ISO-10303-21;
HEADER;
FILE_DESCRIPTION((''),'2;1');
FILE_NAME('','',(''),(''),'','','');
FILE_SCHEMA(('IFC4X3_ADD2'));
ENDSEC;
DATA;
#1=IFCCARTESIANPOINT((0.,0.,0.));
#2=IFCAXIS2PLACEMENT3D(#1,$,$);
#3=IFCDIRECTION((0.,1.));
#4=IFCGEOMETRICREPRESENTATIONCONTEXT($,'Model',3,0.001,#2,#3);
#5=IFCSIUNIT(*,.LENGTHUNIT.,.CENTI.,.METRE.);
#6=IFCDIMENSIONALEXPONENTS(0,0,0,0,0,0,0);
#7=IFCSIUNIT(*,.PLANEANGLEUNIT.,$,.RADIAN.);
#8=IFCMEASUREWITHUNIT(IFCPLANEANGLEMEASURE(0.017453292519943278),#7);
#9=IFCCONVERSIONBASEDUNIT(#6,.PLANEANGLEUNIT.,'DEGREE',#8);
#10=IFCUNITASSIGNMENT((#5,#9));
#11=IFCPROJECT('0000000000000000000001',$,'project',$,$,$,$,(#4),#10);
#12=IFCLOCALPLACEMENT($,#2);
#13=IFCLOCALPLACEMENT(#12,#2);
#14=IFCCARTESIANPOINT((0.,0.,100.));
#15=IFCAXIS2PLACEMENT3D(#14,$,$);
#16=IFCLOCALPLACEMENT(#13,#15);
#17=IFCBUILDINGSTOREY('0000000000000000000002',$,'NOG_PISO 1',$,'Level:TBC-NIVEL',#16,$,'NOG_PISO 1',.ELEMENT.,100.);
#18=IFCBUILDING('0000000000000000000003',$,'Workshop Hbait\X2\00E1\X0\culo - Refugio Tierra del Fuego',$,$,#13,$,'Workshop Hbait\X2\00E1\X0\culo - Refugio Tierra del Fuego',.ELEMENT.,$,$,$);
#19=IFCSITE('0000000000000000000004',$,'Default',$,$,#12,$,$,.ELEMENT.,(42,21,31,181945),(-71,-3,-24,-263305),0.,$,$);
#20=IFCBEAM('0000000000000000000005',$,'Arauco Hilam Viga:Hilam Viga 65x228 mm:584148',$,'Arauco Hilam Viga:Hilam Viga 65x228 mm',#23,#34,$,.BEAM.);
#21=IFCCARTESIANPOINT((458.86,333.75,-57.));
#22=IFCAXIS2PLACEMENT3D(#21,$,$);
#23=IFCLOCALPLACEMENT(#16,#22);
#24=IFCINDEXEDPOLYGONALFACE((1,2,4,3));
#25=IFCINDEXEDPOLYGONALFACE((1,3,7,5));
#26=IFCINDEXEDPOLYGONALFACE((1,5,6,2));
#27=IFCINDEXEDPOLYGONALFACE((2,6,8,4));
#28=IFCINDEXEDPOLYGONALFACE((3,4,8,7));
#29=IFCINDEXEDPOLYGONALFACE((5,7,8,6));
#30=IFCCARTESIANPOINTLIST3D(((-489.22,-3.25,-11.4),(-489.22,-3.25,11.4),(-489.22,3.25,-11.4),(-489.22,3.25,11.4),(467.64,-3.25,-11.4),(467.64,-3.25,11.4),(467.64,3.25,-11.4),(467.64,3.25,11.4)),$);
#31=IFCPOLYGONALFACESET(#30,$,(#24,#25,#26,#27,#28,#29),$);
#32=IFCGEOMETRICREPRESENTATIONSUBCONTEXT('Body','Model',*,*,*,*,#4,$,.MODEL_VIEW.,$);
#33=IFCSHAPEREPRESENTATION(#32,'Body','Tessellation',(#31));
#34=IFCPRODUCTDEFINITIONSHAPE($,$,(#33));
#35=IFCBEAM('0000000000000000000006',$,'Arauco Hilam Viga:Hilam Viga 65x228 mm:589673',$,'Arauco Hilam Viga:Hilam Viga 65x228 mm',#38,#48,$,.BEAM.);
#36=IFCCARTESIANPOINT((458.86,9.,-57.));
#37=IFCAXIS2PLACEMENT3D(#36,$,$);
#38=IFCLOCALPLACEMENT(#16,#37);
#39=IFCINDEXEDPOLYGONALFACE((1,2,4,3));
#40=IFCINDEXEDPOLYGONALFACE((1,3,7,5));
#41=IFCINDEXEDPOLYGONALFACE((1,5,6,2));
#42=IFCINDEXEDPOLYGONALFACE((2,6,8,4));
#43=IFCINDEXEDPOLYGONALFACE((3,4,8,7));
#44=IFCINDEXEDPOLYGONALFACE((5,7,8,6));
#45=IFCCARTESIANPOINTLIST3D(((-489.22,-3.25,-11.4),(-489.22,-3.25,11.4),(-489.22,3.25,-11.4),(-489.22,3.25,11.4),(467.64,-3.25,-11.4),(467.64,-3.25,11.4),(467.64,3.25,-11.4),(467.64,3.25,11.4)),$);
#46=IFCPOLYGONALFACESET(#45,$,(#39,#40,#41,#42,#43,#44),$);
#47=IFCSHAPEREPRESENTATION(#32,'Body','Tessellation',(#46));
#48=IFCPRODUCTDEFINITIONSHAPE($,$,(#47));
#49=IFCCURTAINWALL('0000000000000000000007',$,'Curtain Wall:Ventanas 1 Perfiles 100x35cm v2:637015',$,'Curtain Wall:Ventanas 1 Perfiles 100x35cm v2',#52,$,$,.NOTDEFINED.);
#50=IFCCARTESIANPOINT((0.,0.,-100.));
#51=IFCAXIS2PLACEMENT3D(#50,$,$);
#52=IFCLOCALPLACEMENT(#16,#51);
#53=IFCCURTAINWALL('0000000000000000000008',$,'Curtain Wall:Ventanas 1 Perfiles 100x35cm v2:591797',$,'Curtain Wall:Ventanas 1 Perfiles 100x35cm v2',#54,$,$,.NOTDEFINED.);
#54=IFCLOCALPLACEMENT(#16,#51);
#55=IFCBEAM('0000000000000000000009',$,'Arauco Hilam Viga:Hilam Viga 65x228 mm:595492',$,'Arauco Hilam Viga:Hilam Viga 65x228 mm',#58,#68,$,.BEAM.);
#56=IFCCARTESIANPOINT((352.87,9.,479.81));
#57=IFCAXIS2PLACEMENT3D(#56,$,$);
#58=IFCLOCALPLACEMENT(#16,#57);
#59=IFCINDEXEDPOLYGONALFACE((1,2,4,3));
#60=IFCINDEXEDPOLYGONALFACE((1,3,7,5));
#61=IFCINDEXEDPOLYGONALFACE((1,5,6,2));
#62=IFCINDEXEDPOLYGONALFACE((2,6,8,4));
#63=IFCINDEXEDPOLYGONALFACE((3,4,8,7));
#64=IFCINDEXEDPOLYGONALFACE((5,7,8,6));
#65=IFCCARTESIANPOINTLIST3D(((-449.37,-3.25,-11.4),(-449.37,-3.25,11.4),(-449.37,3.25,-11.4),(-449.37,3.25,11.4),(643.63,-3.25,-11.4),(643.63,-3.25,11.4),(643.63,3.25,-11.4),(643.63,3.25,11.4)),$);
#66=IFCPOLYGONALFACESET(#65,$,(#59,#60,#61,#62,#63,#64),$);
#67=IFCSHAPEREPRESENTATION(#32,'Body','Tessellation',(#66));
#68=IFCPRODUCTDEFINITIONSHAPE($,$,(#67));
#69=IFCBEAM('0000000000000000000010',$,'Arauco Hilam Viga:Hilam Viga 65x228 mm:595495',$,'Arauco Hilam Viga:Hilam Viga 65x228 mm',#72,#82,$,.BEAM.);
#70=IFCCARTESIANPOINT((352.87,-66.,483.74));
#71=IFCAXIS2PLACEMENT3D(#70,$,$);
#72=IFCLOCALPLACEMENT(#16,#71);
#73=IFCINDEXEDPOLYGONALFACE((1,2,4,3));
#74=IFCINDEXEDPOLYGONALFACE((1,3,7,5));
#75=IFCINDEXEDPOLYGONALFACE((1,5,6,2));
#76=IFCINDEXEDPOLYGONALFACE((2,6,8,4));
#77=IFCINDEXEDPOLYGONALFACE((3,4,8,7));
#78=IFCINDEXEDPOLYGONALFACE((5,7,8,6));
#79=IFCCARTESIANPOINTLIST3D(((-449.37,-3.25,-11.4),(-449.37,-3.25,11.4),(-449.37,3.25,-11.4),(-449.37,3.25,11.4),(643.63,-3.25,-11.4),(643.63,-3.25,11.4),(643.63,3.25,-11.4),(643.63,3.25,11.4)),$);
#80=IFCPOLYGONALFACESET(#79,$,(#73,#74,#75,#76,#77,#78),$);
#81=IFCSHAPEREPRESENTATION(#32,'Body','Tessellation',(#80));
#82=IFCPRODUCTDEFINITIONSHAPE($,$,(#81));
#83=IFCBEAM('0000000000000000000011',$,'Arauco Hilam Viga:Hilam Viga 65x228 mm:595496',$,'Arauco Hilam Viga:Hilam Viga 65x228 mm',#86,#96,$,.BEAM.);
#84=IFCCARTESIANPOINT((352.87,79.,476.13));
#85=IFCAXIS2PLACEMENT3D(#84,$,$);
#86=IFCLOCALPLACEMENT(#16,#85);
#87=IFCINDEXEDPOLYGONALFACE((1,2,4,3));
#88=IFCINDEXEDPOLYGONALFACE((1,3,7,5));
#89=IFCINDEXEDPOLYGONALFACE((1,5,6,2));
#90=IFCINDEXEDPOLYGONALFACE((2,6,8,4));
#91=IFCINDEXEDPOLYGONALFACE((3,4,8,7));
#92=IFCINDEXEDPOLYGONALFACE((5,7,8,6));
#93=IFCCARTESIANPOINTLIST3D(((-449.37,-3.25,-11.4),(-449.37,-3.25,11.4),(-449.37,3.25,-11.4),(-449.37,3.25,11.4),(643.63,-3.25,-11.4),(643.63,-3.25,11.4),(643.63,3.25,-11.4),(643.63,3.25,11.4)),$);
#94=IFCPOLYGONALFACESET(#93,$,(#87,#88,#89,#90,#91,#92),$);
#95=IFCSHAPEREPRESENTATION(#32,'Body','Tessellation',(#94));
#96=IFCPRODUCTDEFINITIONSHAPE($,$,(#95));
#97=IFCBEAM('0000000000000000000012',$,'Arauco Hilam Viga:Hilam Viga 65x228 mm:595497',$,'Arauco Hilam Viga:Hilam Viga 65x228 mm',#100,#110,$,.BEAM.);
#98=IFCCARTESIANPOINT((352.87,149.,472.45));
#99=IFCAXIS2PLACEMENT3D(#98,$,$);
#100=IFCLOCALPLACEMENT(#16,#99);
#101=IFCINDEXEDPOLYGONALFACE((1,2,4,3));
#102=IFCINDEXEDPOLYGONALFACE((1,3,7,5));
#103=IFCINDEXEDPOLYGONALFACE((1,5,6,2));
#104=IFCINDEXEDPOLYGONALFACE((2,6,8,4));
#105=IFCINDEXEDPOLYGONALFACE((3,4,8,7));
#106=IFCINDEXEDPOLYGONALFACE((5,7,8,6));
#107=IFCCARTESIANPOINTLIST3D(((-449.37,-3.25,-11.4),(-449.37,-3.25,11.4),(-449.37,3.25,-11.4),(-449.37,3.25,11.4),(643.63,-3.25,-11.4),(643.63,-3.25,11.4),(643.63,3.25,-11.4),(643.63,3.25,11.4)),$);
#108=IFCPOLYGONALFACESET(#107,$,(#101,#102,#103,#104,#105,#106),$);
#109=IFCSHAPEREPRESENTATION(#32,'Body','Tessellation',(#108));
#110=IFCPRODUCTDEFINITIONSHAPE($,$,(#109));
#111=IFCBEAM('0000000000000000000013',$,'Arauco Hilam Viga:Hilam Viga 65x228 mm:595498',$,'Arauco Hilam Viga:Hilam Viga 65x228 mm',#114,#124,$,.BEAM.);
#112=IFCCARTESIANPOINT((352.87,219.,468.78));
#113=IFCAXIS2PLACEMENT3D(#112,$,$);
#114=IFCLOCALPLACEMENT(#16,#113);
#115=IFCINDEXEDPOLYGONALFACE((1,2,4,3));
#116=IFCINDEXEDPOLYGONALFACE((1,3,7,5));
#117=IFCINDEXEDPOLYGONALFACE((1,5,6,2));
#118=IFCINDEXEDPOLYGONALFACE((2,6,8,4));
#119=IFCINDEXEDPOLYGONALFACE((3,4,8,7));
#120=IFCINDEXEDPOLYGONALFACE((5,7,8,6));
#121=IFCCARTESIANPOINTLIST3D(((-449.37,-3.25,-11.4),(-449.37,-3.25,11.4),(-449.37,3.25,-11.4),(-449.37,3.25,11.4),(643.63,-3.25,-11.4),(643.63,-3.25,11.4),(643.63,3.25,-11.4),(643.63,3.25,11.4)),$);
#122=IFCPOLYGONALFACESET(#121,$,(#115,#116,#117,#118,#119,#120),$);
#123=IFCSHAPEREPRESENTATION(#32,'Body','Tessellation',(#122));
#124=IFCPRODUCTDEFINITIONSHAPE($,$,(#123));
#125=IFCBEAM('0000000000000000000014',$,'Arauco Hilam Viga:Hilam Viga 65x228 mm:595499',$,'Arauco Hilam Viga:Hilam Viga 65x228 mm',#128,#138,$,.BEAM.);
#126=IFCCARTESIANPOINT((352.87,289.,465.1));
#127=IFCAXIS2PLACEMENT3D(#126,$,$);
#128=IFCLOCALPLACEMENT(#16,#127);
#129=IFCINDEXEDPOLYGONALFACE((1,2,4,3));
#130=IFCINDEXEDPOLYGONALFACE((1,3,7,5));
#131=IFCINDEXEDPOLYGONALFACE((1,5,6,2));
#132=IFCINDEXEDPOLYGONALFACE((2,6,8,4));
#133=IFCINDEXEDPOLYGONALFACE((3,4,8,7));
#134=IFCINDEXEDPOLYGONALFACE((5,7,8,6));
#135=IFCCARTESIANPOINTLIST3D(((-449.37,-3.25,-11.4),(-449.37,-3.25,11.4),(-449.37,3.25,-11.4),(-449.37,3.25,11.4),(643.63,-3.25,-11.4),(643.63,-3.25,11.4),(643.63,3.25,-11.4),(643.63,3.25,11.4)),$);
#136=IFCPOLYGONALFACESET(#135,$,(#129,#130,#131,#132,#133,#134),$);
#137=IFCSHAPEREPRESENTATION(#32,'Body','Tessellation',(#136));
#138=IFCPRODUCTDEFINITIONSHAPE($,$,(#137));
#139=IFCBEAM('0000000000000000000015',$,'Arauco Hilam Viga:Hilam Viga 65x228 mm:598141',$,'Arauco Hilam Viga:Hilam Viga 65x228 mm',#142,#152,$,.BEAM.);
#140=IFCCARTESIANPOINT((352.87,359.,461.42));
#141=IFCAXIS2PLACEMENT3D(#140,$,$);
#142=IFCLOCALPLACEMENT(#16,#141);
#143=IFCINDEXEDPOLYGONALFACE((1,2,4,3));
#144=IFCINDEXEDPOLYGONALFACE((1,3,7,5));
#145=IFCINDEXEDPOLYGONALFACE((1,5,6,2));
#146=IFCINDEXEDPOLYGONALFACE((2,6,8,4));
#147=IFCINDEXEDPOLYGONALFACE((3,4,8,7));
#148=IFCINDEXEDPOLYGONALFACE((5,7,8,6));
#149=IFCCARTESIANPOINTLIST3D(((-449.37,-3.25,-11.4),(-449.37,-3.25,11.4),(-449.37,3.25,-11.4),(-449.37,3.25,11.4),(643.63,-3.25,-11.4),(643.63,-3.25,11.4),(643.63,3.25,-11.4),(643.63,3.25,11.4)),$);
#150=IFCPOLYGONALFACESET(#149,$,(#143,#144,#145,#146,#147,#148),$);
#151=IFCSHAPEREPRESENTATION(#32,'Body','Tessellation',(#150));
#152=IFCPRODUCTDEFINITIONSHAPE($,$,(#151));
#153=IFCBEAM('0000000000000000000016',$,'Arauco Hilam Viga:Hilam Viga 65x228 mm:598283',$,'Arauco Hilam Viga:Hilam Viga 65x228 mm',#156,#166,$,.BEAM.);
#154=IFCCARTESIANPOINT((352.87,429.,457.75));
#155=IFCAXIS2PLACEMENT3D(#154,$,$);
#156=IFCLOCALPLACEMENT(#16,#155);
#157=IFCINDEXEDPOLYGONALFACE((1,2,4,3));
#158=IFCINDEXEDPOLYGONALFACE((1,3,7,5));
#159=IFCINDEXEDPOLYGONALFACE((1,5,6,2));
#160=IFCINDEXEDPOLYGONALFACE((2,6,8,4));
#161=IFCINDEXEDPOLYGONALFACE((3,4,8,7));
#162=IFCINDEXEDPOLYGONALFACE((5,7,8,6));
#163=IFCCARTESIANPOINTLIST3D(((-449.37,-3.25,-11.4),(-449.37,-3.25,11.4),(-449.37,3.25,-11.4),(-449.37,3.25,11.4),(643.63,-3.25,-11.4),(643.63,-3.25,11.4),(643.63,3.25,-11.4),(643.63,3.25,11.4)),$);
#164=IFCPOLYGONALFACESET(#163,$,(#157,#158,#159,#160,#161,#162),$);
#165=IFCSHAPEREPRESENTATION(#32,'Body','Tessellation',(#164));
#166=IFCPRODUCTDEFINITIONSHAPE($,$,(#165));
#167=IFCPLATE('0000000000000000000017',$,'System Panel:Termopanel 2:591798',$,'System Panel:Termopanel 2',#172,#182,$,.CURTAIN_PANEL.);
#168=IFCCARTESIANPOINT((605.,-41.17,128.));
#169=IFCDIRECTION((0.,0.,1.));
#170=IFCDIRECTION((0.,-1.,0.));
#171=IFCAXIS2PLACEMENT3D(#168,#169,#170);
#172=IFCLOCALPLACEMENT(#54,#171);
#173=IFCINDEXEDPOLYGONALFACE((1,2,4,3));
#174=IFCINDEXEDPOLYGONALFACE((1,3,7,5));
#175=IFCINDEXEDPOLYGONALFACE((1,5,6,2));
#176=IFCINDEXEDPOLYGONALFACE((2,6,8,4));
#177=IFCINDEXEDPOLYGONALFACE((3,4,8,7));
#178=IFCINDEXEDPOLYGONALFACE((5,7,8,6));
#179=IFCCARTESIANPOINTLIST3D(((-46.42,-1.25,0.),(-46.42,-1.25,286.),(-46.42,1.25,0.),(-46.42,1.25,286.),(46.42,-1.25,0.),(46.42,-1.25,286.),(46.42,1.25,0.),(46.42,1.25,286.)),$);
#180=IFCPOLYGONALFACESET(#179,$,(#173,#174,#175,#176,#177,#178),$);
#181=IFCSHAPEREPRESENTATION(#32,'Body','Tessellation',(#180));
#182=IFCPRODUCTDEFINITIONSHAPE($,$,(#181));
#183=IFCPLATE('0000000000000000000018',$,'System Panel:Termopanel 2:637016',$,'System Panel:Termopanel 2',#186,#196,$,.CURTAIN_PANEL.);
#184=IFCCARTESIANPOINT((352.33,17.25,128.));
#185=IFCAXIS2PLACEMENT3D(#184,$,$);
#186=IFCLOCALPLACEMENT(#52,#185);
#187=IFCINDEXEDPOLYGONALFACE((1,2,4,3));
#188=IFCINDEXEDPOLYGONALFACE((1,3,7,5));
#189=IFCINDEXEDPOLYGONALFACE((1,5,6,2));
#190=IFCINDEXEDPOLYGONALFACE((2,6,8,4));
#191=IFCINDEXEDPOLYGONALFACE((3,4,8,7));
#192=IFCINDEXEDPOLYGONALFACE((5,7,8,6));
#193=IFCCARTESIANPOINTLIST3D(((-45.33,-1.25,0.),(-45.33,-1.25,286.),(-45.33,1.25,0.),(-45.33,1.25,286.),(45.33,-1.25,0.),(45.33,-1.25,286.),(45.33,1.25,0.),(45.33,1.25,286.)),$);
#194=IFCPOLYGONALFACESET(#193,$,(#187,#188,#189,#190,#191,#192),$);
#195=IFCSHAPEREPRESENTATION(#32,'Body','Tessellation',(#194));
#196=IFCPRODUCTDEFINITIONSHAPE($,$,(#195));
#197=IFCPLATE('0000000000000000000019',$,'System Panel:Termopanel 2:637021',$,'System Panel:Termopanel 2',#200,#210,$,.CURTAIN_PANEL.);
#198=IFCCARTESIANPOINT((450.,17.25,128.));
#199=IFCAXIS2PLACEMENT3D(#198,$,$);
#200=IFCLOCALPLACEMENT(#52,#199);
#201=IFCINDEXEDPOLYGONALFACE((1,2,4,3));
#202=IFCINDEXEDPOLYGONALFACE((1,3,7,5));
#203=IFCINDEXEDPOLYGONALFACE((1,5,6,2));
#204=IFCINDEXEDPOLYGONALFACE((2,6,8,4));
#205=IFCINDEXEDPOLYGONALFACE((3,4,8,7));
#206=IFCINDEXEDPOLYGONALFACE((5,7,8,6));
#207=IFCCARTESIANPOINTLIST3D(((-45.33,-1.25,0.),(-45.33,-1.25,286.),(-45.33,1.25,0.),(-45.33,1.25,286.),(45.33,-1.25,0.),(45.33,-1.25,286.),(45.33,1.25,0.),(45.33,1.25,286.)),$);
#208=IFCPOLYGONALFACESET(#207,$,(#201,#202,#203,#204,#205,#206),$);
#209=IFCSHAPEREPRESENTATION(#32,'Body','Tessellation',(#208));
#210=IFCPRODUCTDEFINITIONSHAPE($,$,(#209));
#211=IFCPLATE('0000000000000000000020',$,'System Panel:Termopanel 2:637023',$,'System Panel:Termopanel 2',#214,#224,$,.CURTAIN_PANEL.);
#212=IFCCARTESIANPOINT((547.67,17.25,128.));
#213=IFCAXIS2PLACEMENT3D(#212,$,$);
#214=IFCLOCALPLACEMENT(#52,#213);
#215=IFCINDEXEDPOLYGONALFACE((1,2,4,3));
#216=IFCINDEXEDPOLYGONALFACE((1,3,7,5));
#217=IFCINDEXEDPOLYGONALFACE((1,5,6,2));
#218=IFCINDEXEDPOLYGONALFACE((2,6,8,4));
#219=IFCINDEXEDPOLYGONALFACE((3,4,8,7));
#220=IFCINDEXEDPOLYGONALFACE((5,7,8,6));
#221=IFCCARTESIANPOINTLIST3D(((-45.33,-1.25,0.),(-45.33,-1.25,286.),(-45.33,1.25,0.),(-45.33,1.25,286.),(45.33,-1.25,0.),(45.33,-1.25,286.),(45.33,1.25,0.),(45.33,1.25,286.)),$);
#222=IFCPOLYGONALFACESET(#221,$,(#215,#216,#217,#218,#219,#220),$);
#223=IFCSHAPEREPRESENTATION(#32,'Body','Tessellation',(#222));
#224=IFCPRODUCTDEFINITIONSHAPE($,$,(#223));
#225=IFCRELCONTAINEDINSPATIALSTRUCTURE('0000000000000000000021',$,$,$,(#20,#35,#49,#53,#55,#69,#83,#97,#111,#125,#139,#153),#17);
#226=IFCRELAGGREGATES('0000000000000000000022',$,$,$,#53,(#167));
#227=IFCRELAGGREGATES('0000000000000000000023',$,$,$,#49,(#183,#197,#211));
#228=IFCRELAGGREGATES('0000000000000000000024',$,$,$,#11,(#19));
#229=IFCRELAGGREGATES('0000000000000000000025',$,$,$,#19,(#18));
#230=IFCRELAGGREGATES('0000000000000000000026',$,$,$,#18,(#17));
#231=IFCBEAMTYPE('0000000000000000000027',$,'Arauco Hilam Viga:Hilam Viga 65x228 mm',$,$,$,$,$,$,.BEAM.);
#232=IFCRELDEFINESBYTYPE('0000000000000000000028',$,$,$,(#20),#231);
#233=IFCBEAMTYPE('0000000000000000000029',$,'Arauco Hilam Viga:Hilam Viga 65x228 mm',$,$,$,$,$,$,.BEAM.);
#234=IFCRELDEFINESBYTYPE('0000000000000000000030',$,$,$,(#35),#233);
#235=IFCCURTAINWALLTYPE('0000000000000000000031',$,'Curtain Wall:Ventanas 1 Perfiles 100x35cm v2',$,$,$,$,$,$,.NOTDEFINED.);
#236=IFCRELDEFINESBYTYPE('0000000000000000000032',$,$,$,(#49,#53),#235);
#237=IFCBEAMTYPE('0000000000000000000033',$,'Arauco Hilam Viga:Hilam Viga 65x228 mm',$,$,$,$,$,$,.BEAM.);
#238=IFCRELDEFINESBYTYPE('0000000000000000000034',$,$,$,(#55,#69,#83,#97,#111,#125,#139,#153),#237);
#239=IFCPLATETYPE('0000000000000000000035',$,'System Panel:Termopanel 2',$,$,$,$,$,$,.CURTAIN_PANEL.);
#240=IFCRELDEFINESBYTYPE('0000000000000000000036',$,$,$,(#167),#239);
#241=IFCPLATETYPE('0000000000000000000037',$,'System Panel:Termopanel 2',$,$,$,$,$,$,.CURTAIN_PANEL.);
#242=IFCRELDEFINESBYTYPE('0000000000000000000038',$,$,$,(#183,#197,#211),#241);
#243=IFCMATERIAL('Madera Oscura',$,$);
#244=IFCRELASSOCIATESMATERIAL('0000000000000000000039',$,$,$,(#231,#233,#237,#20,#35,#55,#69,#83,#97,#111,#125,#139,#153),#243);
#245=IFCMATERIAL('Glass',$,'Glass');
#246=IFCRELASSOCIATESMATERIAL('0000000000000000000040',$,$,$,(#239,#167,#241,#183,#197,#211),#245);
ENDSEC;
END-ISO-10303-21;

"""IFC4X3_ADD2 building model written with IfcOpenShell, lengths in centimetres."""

from ifc_helpers import new_model, entity, si_unit, converted_unit, direction, frame, origin, origin_2d_with_axis, place, context, subcontext, project, spatial, rectangle, extrude, source, transform, mapped, material, material_profile, profile_set, profile_usage, type_object, type_shapes, element, aggregate, save


model = new_model("IFC4X3_ADD2")

# Units and contexts
model_context = context("Model", 3, precision=0.001, world=origin(), true_north=direction((0.0, 1.0)))
body_context = subcontext(model_context, "Body", "Model", "MODEL_VIEW")
ifc_project = project(units=[si_unit("LENGTHUNIT", "METRE", prefix="CENTI"), converted_unit("PLANEANGLEUNIT", "DEGREE", entity("IfcPlaneAngleMeasure", 0.017453292519943278), si_unit("PLANEANGLEUNIT", "RADIAN"), dimensions=[0, 0, 0, 0, 0, 0, 0])], contexts=[model_context])

# Site, building, storey
site_placement = place(None, origin())
site = spatial("IfcSite", under=ifc_project, at=site_placement, Name="Default", CompositionType="ELEMENT", RefLatitude=(42, 21, 31, 181945), RefLongitude=(-71, -3, -24, -263305), RefElevation=0.0)
building_placement = place(site_placement, origin())
building = spatial("IfcBuilding", under=site, at=building_placement, Name="Workshop Hbaitáculo - Refugio Tierra del Fuego", LongName="Workshop Hbaitáculo - Refugio Tierra del Fuego", CompositionType="ELEMENT")
storey_placement = place(building_placement, frame((0.0, 0.0, 100.0)))
storey = spatial("IfcBuildingStorey", under=building, at=storey_placement, Name="NOG_PISO 1", ObjectType="Level:TBC-NIVEL", LongName="NOG_PISO 1", CompositionType="ELEMENT", Elevation=100.0)

# Beams
ifc_material_1 = material(Name="Madera Oscura")
ifc_material_profile_1 = material_profile(ifc_material_1, rectangle(XDim=930.0, YDim=6.5, at=origin_2d_with_axis()), Name="Hilam Viga 65x228 mm")
ifc_profile_set_1 = profile_set([ifc_material_profile_1], Name="Hilam Viga 65x228 mm")
ifc_profile_usage_1 = profile_usage(ifc_profile_set_1, cardinal=8)
beam_type_1 = type_object("IfcBeamType", Name="Arauco Hilam Viga:Hilam Viga 65x228 mm", PredefinedType="BEAM", material=ifc_profile_set_1)
shared_shape_1 = source(origin(), body_context, "Body", "SweptSolid", [
    extrude(rectangle(XDim=956.86, YDim=6.5, at=origin_2d_with_axis()), frame((-10.79, 0.0, -11.4), z_axis=(0.0, 0.0, 1.0), x_axis=(-1.0, 0.0, 0.0)), (0.0, 0.0, 1.0), 22.8),
])
type_shapes(beam_type_1, [shared_shape_1])
beam_1_placement = place(storey_placement, frame((458.86, 333.75, -57.0)))
element("IfcBeam", 1, at=beam_1_placement, inside=storey, type_object=beam_type_1, material=ifc_profile_usage_1, Name="Arauco Hilam Viga:Hilam Viga 65x228 mm:584148", ObjectType="Arauco Hilam Viga:Hilam Viga 65x228 mm", PredefinedType="BEAM", context=body_context, shape_type="MappedRepresentation", body=[
    mapped(shared_shape_1, transform((0.0, 0.0, 0.0), scale=1.0)),
])
beam_type_2 = type_object("IfcBeamType", Name="Arauco Hilam Viga:Hilam Viga 65x228 mm", PredefinedType="BEAM", material=ifc_profile_set_1)
shared_shape_2 = source(origin(), body_context, "Body", "SweptSolid", [
    extrude(rectangle(XDim=6.5, YDim=956.86, at=origin_2d_with_axis()), frame((-10.79, 0.0, -11.4), z_axis=(0.0, 0.0, 1.0), x_axis=(0.0, 1.0, 0.0)), (0.0, 0.0, 1.0), 22.8),
])
type_shapes(beam_type_2, [shared_shape_2])
beam_2_placement = place(storey_placement, frame((458.86, 9.0, -57.0)))
element("IfcBeam", 2, at=beam_2_placement, inside=storey, type_object=beam_type_2, material=ifc_profile_usage_1, Name="Arauco Hilam Viga:Hilam Viga 65x228 mm:589673", ObjectType="Arauco Hilam Viga:Hilam Viga 65x228 mm", PredefinedType="BEAM", context=body_context, shape_type="MappedRepresentation", body=[
    mapped(shared_shape_2, transform((0.0, 0.0, 0.0), scale=1.0)),
])

# Curtain walls
curtain_wall_type = type_object("IfcCurtainWallType", Name="Curtain Wall:Ventanas 1 Perfiles 100x35cm v2", PredefinedType="NOTDEFINED")
curtain_wall_1_placement = place(storey_placement, frame((0.0, 0.0, -100.0)))
curtain_wall_1 = element("IfcCurtainWall", 3, at=curtain_wall_1_placement, inside=storey, type_object=curtain_wall_type, Name="Curtain Wall:Ventanas 1 Perfiles 100x35cm v2:637015", ObjectType="Curtain Wall:Ventanas 1 Perfiles 100x35cm v2", PredefinedType="NOTDEFINED")
curtain_wall_2_placement = place(storey_placement, frame((0.0, 0.0, -100.0)))
curtain_wall_2 = element("IfcCurtainWall", 4, at=curtain_wall_2_placement, inside=storey, type_object=curtain_wall_type, Name="Curtain Wall:Ventanas 1 Perfiles 100x35cm v2:591797", ObjectType="Curtain Wall:Ventanas 1 Perfiles 100x35cm v2", PredefinedType="NOTDEFINED")

# Beams
beam_type_3 = type_object("IfcBeamType", Name="Arauco Hilam Viga:Hilam Viga 65x228 mm", PredefinedType="BEAM", material=ifc_profile_set_1)
shared_shape_3 = source(origin(), body_context, "Body", "SweptSolid", [
    extrude(rectangle(XDim=1093.0, YDim=6.5, at=origin_2d_with_axis()), frame((97.13, 0.0, -11.4), z_axis=(0.0, 0.0, 1.0), x_axis=(-1.0, 0.0, 0.0)), (0.0, 0.0, 1.0), 22.8),
])
type_shapes(beam_type_3, [shared_shape_3])
for number, where, name in (
    (5, (352.87, 9.0, 479.81), "Arauco Hilam Viga:Hilam Viga 65x228 mm:595492"),
    (6, (352.87, -66.0, 483.74), "Arauco Hilam Viga:Hilam Viga 65x228 mm:595495"),
    (7, (352.87, 79.0, 476.13), "Arauco Hilam Viga:Hilam Viga 65x228 mm:595496"),
    (8, (352.87, 149.0, 472.45), "Arauco Hilam Viga:Hilam Viga 65x228 mm:595497"),
    (9, (352.87, 219.0, 468.78), "Arauco Hilam Viga:Hilam Viga 65x228 mm:595498"),
    (10, (352.87, 289.0, 465.1), "Arauco Hilam Viga:Hilam Viga 65x228 mm:595499"),
    (11, (352.87, 359.0, 461.42), "Arauco Hilam Viga:Hilam Viga 65x228 mm:598141"),
    (12, (352.87, 429.0, 457.75), "Arauco Hilam Viga:Hilam Viga 65x228 mm:598283"),
):
    element("IfcBeam", number, at=place(storey_placement, frame(where)), inside=storey, type_object=beam_type_3, material=ifc_profile_usage_1, Name=name, ObjectType="Arauco Hilam Viga:Hilam Viga 65x228 mm", PredefinedType="BEAM", context=body_context, shape_type="MappedRepresentation", body=[
        mapped(shared_shape_3, transform((0.0, 0.0, 0.0), scale=1.0)),
    ])

# Plates
ifc_material_2 = material(Name="Glass", Category="Glass")
plate_type_1 = type_object("IfcPlateType", Name="System Panel:Termopanel 2", PredefinedType="CURTAIN_PANEL", material=ifc_material_2)
shared_shape_4 = source(origin(), body_context, "Body", "SweptSolid", [
    extrude(rectangle(XDim=2.5, YDim=92.83, at=origin_2d_with_axis()), frame((0.0, 0.0, 0.0), z_axis=(0.0, 0.0, 1.0), x_axis=(0.0, 1.0, 0.0)), (0.0, 0.0, 1.0), 286.0),
])
type_shapes(plate_type_1, [shared_shape_4])
plate_1_placement = place(curtain_wall_2_placement, frame((605.0, -41.17, 128.0), z_axis=(0.0, 0.0, 1.0), x_axis=(0.0, -1.0, 0.0)))
plate_1 = element("IfcPlate", 13, at=plate_1_placement, type_object=plate_type_1, material=ifc_material_2, Name="System Panel:Termopanel 2:591798", ObjectType="System Panel:Termopanel 2", PredefinedType="CURTAIN_PANEL", context=body_context, shape_type="MappedRepresentation", body=[
    mapped(shared_shape_4, transform((0.0, 0.0, 0.0), scale=1.0)),
])
aggregate(curtain_wall_2, [plate_1])
plate_type_2 = type_object("IfcPlateType", Name="System Panel:Termopanel 2", PredefinedType="CURTAIN_PANEL", material=ifc_material_2)
shared_shape_5 = source(origin(), body_context, "Body", "SweptSolid", [
    extrude(rectangle(XDim=2.5, YDim=90.67, at=origin_2d_with_axis()), frame((0.0, 0.0, 0.0), z_axis=(0.0, 0.0, 1.0), x_axis=(0.0, 1.0, 0.0)), (0.0, 0.0, 1.0), 286.0),
])
type_shapes(plate_type_2, [shared_shape_5])
plate_2_placement = place(curtain_wall_1_placement, frame((352.33, 17.25, 128.0)))
plate_2 = element("IfcPlate", 14, at=plate_2_placement, type_object=plate_type_2, material=ifc_material_2, Name="System Panel:Termopanel 2:637016", ObjectType="System Panel:Termopanel 2", PredefinedType="CURTAIN_PANEL", context=body_context, shape_type="MappedRepresentation", body=[
    mapped(shared_shape_5, transform((0.0, 0.0, 0.0), scale=1.0)),
])
plate_3_placement = place(curtain_wall_1_placement, frame((450.0, 17.25, 128.0)))
plate_3 = element("IfcPlate", 15, at=plate_3_placement, type_object=plate_type_2, material=ifc_material_2, Name="System Panel:Termopanel 2:637021", ObjectType="System Panel:Termopanel 2", PredefinedType="CURTAIN_PANEL", context=body_context, shape_type="MappedRepresentation", body=[
    mapped(shared_shape_5, transform((0.0, 0.0, 0.0), scale=1.0)),
])
plate_4_placement = place(curtain_wall_1_placement, frame((547.67, 17.25, 128.0)))
plate_4 = element("IfcPlate", 16, at=plate_4_placement, type_object=plate_type_2, material=ifc_material_2, Name="System Panel:Termopanel 2:637023", ObjectType="System Panel:Termopanel 2", PredefinedType="CURTAIN_PANEL", context=body_context, shape_type="MappedRepresentation", body=[
    mapped(shared_shape_5, transform((0.0, 0.0, 0.0), scale=1.0)),
])
aggregate(curtain_wall_1, [plate_2, plate_3, plate_4])

save(model, "model.ifc")
